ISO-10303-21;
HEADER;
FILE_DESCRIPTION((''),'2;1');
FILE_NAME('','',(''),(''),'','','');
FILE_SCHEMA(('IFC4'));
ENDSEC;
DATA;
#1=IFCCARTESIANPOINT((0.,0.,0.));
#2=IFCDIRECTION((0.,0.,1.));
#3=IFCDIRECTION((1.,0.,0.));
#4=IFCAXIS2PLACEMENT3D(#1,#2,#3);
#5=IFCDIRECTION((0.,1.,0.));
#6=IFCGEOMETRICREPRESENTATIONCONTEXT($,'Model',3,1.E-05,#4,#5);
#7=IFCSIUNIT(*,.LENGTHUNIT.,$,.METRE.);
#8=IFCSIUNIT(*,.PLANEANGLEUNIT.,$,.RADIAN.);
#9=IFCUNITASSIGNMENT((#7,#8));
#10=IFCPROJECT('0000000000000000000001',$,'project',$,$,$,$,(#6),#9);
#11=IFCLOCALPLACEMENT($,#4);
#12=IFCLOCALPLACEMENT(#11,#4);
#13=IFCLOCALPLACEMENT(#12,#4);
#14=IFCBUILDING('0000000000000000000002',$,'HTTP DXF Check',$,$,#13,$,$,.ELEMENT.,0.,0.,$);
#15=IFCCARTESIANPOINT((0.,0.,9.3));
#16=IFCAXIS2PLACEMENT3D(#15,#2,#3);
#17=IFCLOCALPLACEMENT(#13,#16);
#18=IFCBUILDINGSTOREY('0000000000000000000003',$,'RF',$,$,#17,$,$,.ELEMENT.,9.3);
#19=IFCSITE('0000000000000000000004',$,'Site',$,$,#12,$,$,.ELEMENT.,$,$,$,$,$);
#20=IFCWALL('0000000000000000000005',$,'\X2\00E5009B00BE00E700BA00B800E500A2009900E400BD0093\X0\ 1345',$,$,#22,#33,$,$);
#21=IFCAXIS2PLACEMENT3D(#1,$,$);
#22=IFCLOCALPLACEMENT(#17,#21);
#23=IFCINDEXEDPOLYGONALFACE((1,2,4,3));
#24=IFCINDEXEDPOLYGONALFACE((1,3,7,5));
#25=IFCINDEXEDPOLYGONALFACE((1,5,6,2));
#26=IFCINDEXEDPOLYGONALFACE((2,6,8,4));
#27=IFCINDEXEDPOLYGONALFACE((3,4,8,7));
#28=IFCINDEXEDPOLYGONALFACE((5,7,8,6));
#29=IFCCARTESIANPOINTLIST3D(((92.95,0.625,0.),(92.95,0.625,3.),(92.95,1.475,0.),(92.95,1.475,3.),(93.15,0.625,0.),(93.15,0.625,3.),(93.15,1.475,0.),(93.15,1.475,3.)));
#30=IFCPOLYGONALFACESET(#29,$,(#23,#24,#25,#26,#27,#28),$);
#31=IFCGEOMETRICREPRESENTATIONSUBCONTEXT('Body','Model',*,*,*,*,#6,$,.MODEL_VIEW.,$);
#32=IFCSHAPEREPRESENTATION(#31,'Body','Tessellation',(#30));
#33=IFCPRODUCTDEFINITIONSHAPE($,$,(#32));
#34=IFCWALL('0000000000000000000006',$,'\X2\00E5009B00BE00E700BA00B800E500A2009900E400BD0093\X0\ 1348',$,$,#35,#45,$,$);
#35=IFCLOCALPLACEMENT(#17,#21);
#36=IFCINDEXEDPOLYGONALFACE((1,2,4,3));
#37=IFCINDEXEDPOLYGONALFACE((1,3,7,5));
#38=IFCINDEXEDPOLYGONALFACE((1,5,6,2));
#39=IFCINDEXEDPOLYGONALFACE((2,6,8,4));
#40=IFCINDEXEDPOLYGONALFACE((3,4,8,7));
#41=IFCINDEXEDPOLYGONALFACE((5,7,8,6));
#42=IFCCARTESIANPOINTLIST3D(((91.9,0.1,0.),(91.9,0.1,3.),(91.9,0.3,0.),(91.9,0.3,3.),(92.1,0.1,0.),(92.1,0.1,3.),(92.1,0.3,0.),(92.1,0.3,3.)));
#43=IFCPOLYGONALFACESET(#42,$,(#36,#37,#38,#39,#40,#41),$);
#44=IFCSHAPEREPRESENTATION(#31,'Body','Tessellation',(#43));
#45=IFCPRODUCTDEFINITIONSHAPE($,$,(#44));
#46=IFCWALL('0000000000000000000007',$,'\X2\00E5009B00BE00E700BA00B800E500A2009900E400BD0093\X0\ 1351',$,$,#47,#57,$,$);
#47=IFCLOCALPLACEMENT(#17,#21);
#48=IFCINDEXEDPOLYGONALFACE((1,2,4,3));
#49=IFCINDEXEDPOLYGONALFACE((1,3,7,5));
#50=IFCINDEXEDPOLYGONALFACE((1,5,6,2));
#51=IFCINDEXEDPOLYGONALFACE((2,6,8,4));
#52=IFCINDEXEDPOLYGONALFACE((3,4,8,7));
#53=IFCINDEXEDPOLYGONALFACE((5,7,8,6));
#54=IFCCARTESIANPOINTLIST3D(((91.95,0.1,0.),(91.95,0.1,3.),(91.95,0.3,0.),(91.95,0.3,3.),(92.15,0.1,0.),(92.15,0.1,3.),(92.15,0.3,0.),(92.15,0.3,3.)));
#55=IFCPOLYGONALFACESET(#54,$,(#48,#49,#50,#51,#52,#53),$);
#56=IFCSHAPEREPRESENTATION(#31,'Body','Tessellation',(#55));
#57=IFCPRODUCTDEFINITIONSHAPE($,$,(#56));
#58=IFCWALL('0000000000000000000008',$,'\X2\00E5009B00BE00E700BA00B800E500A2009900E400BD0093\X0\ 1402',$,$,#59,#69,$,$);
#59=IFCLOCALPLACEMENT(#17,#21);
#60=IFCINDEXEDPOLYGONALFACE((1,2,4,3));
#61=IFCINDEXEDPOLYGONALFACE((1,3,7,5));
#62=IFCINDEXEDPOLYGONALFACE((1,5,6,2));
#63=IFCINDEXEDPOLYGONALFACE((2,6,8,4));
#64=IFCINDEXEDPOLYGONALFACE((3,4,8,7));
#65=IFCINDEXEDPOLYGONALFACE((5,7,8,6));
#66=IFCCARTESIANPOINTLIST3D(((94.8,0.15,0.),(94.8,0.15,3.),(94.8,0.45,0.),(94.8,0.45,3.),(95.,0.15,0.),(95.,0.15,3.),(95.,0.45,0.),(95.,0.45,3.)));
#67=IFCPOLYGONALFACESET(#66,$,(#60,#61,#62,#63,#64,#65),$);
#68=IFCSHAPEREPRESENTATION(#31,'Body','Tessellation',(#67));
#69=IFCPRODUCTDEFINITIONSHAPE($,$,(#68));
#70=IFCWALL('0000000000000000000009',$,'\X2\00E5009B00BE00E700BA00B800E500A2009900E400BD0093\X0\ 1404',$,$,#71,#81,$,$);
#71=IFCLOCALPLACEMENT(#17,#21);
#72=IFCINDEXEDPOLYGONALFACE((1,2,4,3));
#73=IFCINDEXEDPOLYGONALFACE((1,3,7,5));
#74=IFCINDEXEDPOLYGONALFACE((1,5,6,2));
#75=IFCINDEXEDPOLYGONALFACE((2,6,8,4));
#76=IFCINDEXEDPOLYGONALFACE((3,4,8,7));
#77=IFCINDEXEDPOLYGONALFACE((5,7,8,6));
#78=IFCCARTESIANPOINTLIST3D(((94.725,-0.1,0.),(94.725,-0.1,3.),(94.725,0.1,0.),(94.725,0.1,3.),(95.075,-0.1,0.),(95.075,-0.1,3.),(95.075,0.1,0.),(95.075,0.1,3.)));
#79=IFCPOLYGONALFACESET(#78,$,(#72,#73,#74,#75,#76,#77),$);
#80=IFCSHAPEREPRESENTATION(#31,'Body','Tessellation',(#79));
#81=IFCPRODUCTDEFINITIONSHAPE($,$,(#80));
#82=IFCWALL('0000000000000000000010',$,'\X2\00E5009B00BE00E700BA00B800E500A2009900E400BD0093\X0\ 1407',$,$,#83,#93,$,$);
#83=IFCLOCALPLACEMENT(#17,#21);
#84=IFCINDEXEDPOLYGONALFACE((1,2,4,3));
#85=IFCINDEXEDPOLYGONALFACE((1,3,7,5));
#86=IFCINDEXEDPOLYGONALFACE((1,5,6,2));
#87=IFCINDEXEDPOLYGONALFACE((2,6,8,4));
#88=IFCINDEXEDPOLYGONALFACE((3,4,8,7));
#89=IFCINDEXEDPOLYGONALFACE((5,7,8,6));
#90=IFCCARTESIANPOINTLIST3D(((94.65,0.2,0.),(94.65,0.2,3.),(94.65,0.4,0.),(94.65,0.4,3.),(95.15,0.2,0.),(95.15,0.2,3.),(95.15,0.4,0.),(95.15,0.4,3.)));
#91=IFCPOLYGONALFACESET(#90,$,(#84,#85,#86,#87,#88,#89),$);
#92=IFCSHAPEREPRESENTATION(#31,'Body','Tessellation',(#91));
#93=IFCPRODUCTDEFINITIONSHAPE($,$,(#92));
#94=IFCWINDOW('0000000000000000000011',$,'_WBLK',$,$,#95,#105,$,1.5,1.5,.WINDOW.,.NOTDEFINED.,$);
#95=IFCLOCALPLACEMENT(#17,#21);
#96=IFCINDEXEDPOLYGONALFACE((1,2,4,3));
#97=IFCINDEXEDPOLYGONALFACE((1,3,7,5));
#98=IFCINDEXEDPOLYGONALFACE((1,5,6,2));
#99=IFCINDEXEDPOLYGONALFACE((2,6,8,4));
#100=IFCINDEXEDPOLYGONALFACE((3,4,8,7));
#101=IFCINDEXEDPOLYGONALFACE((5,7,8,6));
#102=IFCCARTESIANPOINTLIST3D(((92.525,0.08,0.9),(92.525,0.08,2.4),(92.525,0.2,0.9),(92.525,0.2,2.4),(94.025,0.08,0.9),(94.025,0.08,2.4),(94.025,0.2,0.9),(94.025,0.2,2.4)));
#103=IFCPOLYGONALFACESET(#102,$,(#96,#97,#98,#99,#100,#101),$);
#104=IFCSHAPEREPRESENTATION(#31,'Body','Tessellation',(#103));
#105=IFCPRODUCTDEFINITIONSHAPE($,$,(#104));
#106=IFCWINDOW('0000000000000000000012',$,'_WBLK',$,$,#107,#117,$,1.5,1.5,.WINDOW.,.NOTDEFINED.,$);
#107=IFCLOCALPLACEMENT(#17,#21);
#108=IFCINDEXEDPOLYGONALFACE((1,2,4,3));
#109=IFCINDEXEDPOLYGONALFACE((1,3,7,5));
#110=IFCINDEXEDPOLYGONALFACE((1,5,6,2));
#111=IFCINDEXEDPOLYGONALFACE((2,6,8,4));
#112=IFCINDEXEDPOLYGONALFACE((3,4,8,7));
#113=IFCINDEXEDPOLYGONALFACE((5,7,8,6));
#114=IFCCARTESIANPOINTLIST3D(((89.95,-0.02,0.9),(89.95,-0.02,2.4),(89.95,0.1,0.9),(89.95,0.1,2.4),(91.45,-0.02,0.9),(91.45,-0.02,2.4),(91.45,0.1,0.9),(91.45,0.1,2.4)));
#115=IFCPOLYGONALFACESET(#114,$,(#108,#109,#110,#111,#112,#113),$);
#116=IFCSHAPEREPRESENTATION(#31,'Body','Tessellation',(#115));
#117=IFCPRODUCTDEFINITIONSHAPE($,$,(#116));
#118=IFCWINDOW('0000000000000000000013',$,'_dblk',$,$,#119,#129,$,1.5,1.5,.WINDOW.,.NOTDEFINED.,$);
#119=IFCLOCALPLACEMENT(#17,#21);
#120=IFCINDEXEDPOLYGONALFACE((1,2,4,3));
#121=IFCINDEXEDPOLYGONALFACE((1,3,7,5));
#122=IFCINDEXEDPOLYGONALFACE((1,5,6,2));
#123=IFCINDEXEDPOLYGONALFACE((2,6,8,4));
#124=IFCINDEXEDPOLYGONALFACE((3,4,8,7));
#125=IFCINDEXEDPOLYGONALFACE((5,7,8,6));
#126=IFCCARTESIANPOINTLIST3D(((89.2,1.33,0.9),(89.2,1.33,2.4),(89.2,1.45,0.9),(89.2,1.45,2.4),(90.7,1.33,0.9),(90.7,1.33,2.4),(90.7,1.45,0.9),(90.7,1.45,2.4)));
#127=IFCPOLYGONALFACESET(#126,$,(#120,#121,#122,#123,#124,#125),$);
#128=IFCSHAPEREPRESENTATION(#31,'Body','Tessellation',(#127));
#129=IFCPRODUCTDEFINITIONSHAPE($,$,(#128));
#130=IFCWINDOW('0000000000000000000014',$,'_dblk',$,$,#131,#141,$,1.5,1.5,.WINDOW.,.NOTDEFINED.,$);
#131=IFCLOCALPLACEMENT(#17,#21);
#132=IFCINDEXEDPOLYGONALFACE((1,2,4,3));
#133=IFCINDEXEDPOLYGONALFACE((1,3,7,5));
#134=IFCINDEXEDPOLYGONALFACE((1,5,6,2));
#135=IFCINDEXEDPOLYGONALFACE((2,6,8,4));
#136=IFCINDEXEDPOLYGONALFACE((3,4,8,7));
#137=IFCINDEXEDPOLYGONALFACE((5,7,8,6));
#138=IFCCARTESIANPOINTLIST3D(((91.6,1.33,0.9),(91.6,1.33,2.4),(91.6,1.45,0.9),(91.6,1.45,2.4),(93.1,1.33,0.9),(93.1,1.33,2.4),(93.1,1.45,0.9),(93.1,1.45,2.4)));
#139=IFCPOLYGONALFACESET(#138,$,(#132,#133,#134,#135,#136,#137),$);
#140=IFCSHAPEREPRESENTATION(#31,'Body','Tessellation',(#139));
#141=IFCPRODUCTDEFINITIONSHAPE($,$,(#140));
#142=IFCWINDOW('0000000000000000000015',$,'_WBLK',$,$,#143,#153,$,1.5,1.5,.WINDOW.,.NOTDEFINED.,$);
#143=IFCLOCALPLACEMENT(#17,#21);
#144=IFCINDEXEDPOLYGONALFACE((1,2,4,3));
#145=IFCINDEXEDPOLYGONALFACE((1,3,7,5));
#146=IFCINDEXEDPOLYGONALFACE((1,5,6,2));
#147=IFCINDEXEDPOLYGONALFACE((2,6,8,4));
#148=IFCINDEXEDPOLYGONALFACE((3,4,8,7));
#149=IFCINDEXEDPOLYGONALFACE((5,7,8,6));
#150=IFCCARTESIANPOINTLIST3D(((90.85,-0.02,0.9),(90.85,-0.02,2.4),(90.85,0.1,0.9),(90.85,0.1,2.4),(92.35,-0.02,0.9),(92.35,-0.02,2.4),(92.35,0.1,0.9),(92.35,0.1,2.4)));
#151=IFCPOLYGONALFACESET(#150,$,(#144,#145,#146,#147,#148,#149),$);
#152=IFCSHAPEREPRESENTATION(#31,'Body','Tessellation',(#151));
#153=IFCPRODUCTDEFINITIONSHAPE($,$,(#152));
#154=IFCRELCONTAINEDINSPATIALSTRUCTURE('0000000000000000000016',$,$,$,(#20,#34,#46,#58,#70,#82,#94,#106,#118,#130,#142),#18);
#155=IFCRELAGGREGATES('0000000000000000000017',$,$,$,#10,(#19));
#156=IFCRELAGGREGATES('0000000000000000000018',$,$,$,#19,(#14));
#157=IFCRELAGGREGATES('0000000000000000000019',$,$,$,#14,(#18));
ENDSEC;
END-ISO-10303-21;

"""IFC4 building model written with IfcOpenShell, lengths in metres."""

from ifc_helpers import new_model, si_unit, direction, frame, frame_2d, origin_with_axes, place, context, subcontext, project, spatial, rectangle, extrude, element, save


model = new_model("IFC4")

# Units and contexts
model_context = context("Model", 3, precision=1e-05, world=origin_with_axes(), true_north=direction((0.0, 1.0, 0.0)))
body_context = subcontext(model_context, "Body", "Model", "MODEL_VIEW")
ifc_project = project(units=[si_unit("LENGTHUNIT", "METRE"), si_unit("PLANEANGLEUNIT", "RADIAN")], contexts=[model_context])

# Site, building, storey
placement = place(None, origin_with_axes())
site_placement = place(placement, origin_with_axes())
site = spatial("IfcSite", under=ifc_project, at=site_placement, Name="Site", CompositionType="ELEMENT")
building_placement = place(site_placement, origin_with_axes())
building = spatial("IfcBuilding", under=site, at=building_placement, Name="HTTP DXF Check", CompositionType="ELEMENT", ElevationOfRefHeight=0.0, ElevationOfTerrain=0.0)
storey_placement = place(building_placement, frame((0.0, 0.0, 9.3), z_axis=(0.0, 0.0, 1.0), x_axis=(1.0, 0.0, 0.0)))
storey = spatial("IfcBuildingStorey", under=building, at=storey_placement, Name="RF", CompositionType="ELEMENT", Elevation=9.3)

# Walls
for number, where, z_axis, x_axis, name in (
    (1, (93.05, 1.05, 0.0), (0.0, 0.0, 1.0), (0.0, -1.0, 0.0), "å\u009b¾çº¸å¢\u0099ä½\u0093 1345"),
):
    element("IfcWall", number, at=place(storey_placement, frame(where, z_axis=z_axis, x_axis=x_axis)), inside=storey, Name=name, context=body_context, shape_type="SweptSolid", body=[
        extrude(rectangle(XDim=0.85, YDim=0.2, at=frame_2d((0.0, 0.0), x_axis=(1.0, 0.0, 0.0))), frame((0.0, 0.0, 0.0), z_axis=(0.0, 0.0, 1.0)), (0.0, 0.0, 1.0), 3.0),
    ])
for number, where, z_axis, x_axis, name in (
    (2, (92.0, 0.2, 0.0), (0.0, 0.0, 1.0), (1.0, 0.0, 0.0), "å\u009b¾çº¸å¢\u0099ä½\u0093 1348"),
    (3, (92.05, 0.2, 0.0), (0.0, 0.0, 1.0), (0.0, -1.0, 0.0), "å\u009b¾çº¸å¢\u0099ä½\u0093 1351"),
):
    element("IfcWall", number, at=place(storey_placement, frame(where, z_axis=z_axis, x_axis=x_axis)), inside=storey, Name=name, context=body_context, shape_type="SweptSolid", body=[
        extrude(rectangle(XDim=0.2, YDim=0.2, at=frame_2d((0.0, 0.0), x_axis=(1.0, 0.0, 0.0))), frame((0.0, 0.0, 0.0), z_axis=(0.0, 0.0, 1.0)), (0.0, 0.0, 1.0), 3.0),
    ])
wall_1_placement = place(storey_placement, frame((94.9, 0.3, 0.0), z_axis=(0.0, 0.0, 1.0), x_axis=(0.0, -1.0, 0.0)))
element("IfcWall", 4, at=wall_1_placement, inside=storey, Name="å\u009b¾çº¸å¢\u0099ä½\u0093 1402", context=body_context, shape_type="SweptSolid", body=[
    extrude(rectangle(XDim=0.3, YDim=0.2, at=frame_2d((0.0, 0.0), x_axis=(1.0, 0.0, 0.0))), frame((0.0, 0.0, 0.0), z_axis=(0.0, 0.0, 1.0)), (0.0, 0.0, 1.0), 3.0),
])
wall_2_placement = place(storey_placement, frame((94.9, 0.0, 0.0), z_axis=(0.0, 0.0, 1.0), x_axis=(1.0, 0.0, 0.0)))
element("IfcWall", 5, at=wall_2_placement, inside=storey, Name="å\u009b¾çº¸å¢\u0099ä½\u0093 1404", context=body_context, shape_type="SweptSolid", body=[
    extrude(rectangle(XDim=0.35, YDim=0.2, at=frame_2d((0.0, 0.0), x_axis=(1.0, 0.0, 0.0))), frame((0.0, 0.0, 0.0), z_axis=(0.0, 0.0, 1.0)), (0.0, 0.0, 1.0), 3.0),
])
wall_3_placement = place(storey_placement, frame((94.9, 0.3, 0.0), z_axis=(0.0, 0.0, 1.0), x_axis=(1.0, 0.0, 0.0)))
element("IfcWall", 6, at=wall_3_placement, inside=storey, Name="å\u009b¾çº¸å¢\u0099ä½\u0093 1407", context=body_context, shape_type="SweptSolid", body=[
    extrude(rectangle(XDim=0.5, YDim=0.2, at=frame_2d((0.0, 0.0), x_axis=(1.0, 0.0, 0.0))), frame((0.0, 0.0, 0.0), z_axis=(0.0, 0.0, 1.0)), (0.0, 0.0, 1.0), 3.0),
])

# Windows
for number, where, z_axis, x_axis, name in (
    (7, (93.275, 0.14, 0.9), (0.0, 0.0, 1.0), (1.0, 0.0, 0.0), "_WBLK"),
    (8, (90.7, 0.04, 0.9), (0.0, 0.0, 1.0), (1.0, 0.0, 0.0), "_WBLK"),
    (9, (89.95, 1.39, 0.9), (0.0, 0.0, 1.0), (1.0, 0.0, 0.0), "_dblk"),
    (10, (92.35, 1.39, 0.9), (0.0, 0.0, 1.0), (1.0, 0.0, 0.0), "_dblk"),
    (11, (91.6, 0.04, 0.9), (0.0, 0.0, 1.0), (1.0, 0.0, 0.0), "_WBLK"),
):
    element("IfcWindow", number, at=place(storey_placement, frame(where, z_axis=z_axis, x_axis=x_axis)), inside=storey, Name=name, OverallHeight=1.5, OverallWidth=1.5, PartitioningType="NOTDEFINED", PredefinedType="WINDOW", context=body_context, shape_type="SweptSolid", body=[
        extrude(rectangle(XDim=1.5, YDim=0.12, at=frame_2d((0.0, 0.0), x_axis=(1.0, 0.0, 0.0))), frame((0.0, 0.0, 0.0), z_axis=(0.0, 0.0, 1.0)), (0.0, 0.0, 1.0), 1.5),
    ])

save(model, "model.ifc")
